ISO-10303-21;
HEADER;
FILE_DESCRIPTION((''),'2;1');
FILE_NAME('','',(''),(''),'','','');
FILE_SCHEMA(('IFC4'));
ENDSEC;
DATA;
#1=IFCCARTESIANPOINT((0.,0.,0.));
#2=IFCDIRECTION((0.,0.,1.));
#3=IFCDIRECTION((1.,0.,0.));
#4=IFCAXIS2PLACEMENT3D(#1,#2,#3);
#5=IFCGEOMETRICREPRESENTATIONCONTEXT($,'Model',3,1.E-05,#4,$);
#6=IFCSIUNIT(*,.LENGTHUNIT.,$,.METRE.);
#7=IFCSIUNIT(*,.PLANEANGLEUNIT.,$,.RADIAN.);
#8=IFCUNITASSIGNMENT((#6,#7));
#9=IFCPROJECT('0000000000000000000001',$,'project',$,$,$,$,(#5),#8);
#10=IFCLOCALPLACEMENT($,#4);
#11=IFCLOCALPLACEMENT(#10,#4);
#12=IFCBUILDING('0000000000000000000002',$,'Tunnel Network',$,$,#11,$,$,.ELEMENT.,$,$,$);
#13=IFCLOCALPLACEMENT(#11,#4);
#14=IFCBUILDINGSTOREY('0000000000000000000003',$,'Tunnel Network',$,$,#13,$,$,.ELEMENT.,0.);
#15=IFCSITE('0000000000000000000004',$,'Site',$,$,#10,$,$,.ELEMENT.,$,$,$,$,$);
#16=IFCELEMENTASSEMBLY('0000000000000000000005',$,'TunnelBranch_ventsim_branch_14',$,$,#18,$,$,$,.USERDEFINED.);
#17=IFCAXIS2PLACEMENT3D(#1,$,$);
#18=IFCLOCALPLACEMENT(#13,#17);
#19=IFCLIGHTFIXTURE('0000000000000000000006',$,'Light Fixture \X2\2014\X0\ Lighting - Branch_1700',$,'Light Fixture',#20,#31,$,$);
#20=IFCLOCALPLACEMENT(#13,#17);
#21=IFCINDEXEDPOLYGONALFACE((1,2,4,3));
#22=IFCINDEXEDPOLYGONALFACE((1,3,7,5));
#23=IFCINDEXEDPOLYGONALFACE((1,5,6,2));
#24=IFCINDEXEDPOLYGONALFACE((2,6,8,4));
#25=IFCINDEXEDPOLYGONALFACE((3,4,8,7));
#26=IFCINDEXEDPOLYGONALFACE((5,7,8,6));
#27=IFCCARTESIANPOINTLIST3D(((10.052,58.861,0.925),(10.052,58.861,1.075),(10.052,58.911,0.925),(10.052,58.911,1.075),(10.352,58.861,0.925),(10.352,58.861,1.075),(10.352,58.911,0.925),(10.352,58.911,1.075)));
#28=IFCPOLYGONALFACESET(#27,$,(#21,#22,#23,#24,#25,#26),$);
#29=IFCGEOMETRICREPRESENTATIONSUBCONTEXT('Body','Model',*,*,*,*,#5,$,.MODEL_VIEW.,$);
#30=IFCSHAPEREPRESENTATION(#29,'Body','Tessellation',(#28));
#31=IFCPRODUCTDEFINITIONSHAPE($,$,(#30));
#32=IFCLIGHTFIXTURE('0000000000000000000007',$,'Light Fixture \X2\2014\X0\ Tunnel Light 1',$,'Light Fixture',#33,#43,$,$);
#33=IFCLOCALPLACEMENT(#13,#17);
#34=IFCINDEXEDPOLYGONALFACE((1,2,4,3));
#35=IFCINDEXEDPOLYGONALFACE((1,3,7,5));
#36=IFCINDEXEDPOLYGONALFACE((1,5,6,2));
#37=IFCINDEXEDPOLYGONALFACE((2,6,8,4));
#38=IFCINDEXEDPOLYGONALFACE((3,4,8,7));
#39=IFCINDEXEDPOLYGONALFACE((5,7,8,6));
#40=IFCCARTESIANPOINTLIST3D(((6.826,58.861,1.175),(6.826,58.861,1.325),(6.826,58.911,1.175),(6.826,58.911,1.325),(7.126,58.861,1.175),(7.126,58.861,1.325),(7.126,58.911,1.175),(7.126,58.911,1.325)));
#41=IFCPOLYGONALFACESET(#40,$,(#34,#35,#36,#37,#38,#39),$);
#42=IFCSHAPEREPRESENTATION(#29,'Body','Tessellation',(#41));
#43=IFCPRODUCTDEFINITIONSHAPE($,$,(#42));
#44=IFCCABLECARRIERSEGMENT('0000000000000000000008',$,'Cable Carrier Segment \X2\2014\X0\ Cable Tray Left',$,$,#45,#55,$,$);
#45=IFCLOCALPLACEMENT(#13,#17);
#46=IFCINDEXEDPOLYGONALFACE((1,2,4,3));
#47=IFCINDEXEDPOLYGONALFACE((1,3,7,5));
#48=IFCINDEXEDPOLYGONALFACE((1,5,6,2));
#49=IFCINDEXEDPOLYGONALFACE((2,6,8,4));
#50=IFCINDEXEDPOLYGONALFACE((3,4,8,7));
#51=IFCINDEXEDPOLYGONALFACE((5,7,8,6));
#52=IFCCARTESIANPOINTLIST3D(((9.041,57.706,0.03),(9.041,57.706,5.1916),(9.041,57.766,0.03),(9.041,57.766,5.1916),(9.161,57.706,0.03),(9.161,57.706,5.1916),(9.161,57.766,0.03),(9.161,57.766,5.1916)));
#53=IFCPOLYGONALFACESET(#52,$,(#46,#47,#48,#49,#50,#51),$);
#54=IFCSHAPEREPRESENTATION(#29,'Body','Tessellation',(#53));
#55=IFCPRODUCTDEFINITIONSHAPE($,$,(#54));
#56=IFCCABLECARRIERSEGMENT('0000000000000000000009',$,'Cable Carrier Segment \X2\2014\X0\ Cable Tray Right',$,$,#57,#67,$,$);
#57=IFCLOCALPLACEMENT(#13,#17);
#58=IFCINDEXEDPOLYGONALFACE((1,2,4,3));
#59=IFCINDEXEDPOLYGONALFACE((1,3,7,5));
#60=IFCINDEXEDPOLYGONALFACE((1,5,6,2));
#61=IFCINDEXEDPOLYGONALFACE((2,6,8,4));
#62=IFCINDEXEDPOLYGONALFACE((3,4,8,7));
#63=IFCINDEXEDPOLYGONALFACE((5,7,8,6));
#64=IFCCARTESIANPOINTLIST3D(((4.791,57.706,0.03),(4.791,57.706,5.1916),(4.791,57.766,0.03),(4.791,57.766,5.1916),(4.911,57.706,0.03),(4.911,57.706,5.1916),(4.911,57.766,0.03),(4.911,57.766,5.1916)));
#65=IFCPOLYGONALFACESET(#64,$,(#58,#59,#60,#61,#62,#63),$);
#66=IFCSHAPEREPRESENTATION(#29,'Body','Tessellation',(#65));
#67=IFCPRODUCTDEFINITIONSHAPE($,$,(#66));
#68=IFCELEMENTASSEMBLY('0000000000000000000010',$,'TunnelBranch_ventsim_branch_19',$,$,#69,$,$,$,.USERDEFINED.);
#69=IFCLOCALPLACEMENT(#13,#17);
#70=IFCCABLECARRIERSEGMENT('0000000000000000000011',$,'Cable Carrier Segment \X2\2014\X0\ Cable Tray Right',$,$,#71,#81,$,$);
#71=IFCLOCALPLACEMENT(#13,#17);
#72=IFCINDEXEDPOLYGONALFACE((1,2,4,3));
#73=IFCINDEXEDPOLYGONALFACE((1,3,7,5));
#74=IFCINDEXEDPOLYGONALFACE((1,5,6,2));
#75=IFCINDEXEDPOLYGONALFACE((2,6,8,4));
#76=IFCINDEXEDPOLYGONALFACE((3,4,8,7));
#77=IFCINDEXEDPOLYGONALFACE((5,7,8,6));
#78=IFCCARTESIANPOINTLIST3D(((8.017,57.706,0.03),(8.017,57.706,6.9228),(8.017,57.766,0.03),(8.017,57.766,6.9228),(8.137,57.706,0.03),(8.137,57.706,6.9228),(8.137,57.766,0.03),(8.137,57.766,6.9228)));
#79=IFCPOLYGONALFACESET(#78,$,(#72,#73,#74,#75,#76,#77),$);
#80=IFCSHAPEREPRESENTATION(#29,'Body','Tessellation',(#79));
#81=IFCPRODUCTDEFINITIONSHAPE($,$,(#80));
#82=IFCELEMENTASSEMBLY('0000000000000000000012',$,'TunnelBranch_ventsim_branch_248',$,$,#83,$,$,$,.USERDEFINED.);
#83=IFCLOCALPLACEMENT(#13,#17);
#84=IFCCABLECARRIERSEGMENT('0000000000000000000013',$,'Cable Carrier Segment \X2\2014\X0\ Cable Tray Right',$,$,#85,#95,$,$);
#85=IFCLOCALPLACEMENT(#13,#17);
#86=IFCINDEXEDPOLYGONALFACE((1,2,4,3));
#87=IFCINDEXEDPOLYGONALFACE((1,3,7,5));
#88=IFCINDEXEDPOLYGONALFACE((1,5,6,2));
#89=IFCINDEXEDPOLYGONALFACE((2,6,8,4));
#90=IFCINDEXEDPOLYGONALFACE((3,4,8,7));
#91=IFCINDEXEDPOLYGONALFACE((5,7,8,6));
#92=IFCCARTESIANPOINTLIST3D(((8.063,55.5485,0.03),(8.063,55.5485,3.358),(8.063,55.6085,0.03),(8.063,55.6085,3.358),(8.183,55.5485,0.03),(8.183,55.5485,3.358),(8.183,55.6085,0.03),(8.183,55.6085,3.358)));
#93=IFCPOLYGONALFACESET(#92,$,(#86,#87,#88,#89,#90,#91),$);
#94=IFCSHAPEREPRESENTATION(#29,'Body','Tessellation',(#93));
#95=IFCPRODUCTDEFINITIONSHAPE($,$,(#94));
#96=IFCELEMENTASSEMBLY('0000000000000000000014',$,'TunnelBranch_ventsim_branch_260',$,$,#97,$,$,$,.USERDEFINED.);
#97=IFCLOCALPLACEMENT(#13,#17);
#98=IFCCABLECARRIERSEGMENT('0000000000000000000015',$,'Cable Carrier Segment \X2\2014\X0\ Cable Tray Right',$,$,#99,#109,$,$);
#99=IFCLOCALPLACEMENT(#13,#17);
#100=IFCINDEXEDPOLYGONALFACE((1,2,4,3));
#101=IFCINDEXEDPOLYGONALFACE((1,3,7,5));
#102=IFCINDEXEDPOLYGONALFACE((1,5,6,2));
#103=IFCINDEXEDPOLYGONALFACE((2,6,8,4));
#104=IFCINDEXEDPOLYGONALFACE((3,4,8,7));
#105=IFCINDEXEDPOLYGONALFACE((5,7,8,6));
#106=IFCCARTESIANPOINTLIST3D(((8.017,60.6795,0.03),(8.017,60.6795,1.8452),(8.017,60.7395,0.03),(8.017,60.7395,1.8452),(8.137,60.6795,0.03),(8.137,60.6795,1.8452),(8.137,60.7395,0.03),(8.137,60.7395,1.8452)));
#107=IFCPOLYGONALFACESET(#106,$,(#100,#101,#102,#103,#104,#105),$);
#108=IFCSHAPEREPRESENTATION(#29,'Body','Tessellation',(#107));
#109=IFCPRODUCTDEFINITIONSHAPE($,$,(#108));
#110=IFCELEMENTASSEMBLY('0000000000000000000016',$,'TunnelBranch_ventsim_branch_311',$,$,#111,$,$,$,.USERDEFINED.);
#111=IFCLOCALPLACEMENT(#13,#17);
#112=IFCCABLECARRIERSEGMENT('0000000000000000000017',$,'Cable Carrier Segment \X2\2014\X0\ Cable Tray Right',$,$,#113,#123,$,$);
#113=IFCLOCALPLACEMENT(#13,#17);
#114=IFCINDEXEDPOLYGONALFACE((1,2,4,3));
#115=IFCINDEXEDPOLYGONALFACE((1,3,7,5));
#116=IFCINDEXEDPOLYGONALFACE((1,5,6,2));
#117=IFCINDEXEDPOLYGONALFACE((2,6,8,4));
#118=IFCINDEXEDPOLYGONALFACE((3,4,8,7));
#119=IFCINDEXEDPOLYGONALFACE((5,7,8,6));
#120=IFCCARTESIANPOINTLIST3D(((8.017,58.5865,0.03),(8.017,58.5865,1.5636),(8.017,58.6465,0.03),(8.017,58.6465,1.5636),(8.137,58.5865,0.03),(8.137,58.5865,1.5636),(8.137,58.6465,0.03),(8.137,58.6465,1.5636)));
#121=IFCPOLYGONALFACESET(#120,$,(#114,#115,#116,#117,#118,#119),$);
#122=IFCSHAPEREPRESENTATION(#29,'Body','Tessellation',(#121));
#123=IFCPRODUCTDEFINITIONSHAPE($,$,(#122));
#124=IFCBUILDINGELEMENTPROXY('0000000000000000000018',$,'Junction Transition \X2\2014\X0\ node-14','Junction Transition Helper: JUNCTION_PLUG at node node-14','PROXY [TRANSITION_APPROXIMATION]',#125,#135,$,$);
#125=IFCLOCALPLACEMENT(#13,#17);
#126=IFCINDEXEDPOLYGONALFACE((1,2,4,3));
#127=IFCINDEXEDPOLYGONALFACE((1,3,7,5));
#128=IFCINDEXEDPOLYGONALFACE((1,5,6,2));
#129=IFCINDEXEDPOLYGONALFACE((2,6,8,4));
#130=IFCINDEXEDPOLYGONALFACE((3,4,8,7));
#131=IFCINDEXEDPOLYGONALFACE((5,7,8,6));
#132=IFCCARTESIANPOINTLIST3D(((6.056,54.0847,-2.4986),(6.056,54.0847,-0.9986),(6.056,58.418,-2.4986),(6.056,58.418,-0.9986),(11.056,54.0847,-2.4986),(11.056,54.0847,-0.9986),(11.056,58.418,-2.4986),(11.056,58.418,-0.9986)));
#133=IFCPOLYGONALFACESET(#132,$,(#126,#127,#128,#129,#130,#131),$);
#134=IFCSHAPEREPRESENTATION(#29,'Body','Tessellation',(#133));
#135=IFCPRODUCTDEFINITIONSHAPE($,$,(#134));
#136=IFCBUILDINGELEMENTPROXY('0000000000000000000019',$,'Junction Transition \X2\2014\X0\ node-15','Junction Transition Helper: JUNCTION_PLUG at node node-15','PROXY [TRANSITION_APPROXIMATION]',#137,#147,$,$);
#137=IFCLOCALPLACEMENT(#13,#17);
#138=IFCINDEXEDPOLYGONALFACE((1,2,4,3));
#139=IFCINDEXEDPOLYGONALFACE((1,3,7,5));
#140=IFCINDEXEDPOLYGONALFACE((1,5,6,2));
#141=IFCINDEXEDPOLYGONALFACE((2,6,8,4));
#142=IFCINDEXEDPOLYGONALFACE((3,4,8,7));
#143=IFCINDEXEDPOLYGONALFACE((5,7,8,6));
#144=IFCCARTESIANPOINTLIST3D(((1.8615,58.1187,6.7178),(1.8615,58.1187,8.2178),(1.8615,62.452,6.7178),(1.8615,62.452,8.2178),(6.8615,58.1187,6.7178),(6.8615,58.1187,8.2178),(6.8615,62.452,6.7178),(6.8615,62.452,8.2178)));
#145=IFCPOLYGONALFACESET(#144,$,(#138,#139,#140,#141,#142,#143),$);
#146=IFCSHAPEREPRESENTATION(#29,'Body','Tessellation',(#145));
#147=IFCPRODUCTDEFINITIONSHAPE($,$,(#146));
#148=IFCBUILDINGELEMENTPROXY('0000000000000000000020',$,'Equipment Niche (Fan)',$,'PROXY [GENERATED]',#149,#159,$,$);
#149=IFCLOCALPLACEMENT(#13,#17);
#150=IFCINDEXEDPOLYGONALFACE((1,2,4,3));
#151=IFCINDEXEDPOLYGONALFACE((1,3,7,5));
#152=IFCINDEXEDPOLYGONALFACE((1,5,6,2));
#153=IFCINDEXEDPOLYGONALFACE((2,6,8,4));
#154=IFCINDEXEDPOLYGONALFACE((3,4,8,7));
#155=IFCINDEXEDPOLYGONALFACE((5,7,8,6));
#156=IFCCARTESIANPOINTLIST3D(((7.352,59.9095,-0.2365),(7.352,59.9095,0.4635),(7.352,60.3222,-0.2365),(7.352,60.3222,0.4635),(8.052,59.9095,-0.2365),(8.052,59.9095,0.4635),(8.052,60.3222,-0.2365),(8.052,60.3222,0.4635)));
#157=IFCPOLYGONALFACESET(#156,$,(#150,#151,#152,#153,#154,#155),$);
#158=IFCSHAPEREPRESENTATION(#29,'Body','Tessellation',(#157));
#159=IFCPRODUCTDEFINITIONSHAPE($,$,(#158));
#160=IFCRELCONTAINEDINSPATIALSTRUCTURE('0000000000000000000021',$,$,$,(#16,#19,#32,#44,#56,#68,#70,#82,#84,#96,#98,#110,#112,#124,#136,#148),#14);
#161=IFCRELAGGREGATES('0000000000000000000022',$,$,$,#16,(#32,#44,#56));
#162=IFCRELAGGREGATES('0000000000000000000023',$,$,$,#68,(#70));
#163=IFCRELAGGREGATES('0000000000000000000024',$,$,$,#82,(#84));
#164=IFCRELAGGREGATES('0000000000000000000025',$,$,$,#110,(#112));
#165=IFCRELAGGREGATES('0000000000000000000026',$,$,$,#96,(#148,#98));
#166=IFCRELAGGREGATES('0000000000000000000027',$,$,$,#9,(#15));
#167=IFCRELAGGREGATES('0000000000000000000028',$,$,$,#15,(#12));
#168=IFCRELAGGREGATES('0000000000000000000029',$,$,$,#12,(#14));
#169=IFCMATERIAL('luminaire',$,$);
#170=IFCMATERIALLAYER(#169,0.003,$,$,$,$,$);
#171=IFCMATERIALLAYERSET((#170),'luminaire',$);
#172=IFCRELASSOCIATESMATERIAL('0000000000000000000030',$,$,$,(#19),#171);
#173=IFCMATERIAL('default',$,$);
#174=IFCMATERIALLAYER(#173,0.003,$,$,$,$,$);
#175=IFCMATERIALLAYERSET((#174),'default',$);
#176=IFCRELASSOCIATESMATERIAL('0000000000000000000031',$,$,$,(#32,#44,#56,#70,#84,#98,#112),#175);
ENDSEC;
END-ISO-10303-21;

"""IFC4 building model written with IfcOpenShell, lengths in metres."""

from ifc_helpers import new_model, si_unit, frame, origin_with_axes, origin_2d_with_axis, place, context, subcontext, project, spatial, rectangle, extrude, material, layer, layer_set, layer_usage, element, aggregate, save


model = new_model("IFC4")

# Units and contexts
model_context = context("Model", 3, precision=1e-05, world=origin_with_axes())
body_context = subcontext(model_context, "Body", "Model", "MODEL_VIEW")
ifc_project = project(units=[si_unit("LENGTHUNIT", "METRE"), si_unit("PLANEANGLEUNIT", "RADIAN")], contexts=[model_context])

# Site, building, storey
site_placement = place(None, origin_with_axes())
site = spatial("IfcSite", under=ifc_project, at=site_placement, Name="Site", CompositionType="ELEMENT")
building_placement = place(site_placement, origin_with_axes())
building = spatial("IfcBuilding", under=site, at=building_placement, Name="Tunnel Network", CompositionType="ELEMENT")
storey_placement = place(building_placement, origin_with_axes())
storey = spatial("IfcBuildingStorey", under=building, at=storey_placement, Name="Tunnel Network", CompositionType="ELEMENT", Elevation=0.0)

# Element assembly
assembly_1_placement = place(storey_placement, frame((6.976, 58.861, 1.25), z_axis=(0.0, 1.0, 0.0), x_axis=(-1.0, 0.0, 0.0)))
assembly_1 = element("IfcElementAssembly", 1, at=assembly_1_placement, inside=storey, Name="TunnelBranch_ventsim_branch_14", PredefinedType="USERDEFINED")
ifc_material_1 = material(Name="default")
ifc_layer_1 = layer(ifc_material_1, 0.003)
ifc_layer_set_1 = layer_set([ifc_layer_1], Name="default")

# Light fixtures
ifc_material_2 = material(Name="luminaire")
ifc_layer_2 = layer(ifc_material_2, 0.003)
ifc_layer_set_2 = layer_set([ifc_layer_2], Name="luminaire")
ifc_layer_usage_1 = layer_usage(ifc_layer_set_2, "AXIS2", "POSITIVE", 0.0)
light_fixture_1_placement = place(storey_placement, frame((10.202, 58.861, 1.0), z_axis=(0.0, 1.0, 0.0), x_axis=(-1.0, 0.0, 0.0)))
element("IfcLightFixture", 2, at=light_fixture_1_placement, inside=storey, material=ifc_layer_usage_1, Name="Light Fixture — Lighting - Branch_1700", ObjectType="Light Fixture", context=body_context, shape_type="SweptSolid", body=[
    extrude(rectangle(XDim=0.3, YDim=0.15, at=origin_2d_with_axis()), origin_with_axes(), (0.0, 0.0, 1.0), 0.05),
])
ifc_layer_usage_2 = layer_usage(ifc_layer_set_1, "AXIS2", "POSITIVE", 0.0)
light_fixture_2_placement = place(storey_placement, frame((6.976, 58.861, 1.25), z_axis=(0.0, 1.0, 0.0), x_axis=(-1.0, 0.0, 0.0)))
light_fixture_2 = element("IfcLightFixture", 3, at=light_fixture_2_placement, inside=storey, material=ifc_layer_usage_2, Name="Light Fixture — Tunnel Light 1", ObjectType="Light Fixture", context=body_context, shape_type="SweptSolid", body=[
    extrude(rectangle(XDim=0.3, YDim=0.15, at=origin_2d_with_axis()), origin_with_axes(), (0.0, 0.0, 1.0), 0.05),
])

# Cable carrier segments
ifc_layer_usage_3 = layer_usage(ifc_layer_set_1, "AXIS2", "POSITIVE", 0.0)
cable_carrier_segment_1_placement = place(storey_placement, frame((9.101, 57.736, 0.03), z_axis=(0.0, 0.0, 1.0), x_axis=(-1.0, 0.0, 0.0)))
cable_carrier_segment_1 = element("IfcCableCarrierSegment", 4, at=cable_carrier_segment_1_placement, inside=storey, material=ifc_layer_usage_3, Name="Cable Carrier Segment — Cable Tray Left", context=body_context, shape_type="SweptSolid", body=[
    extrude(rectangle(XDim=0.12, YDim=0.06, at=origin_2d_with_axis()), origin_with_axes(), (0.0, 0.0, 1.0), 5.1616),
])
ifc_layer_usage_4 = layer_usage(ifc_layer_set_1, "AXIS2", "POSITIVE", 0.0)
cable_carrier_segment_2_placement = place(storey_placement, frame((4.851, 57.736, 0.03), z_axis=(0.0, 0.0, 1.0), x_axis=(-1.0, 0.0, 0.0)))
cable_carrier_segment_2 = element("IfcCableCarrierSegment", 5, at=cable_carrier_segment_2_placement, inside=storey, material=ifc_layer_usage_4, Name="Cable Carrier Segment — Cable Tray Right", context=body_context, shape_type="SweptSolid", body=[
    extrude(rectangle(XDim=0.12, YDim=0.06, at=origin_2d_with_axis()), origin_with_axes(), (0.0, 0.0, 1.0), 5.1616),
])
aggregate(assembly_1, [light_fixture_2, cable_carrier_segment_1, cable_carrier_segment_2])

# Element assemblies, cable carrier segments
assembly_2_placement = place(storey_placement, frame((10.202, 58.861, 1.0), z_axis=(0.0, 1.0, 0.0), x_axis=(-1.0, 0.0, 0.0)))
assembly_2 = element("IfcElementAssembly", 6, at=assembly_2_placement, inside=storey, Name="TunnelBranch_ventsim_branch_19", PredefinedType="USERDEFINED")
ifc_layer_usage_5 = layer_usage(ifc_layer_set_1, "AXIS2", "POSITIVE", 0.0)
cable_carrier_segment_3_placement = place(storey_placement, frame((8.077, 57.736, 0.03), z_axis=(0.0, 0.0, 1.0), x_axis=(-1.0, 0.0, 0.0)))
cable_carrier_segment_3 = element("IfcCableCarrierSegment", 7, at=cable_carrier_segment_3_placement, inside=storey, material=ifc_layer_usage_5, Name="Cable Carrier Segment — Cable Tray Right", context=body_context, shape_type="SweptSolid", body=[
    extrude(rectangle(XDim=0.12, YDim=0.06, at=origin_2d_with_axis()), origin_with_axes(), (0.0, 0.0, 1.0), 6.8928),
])
aggregate(assembly_2, [cable_carrier_segment_3])
assembly_3_placement = place(storey_placement, frame((10.248, 56.4785, 1.25), z_axis=(0.0, 1.0, 0.0), x_axis=(-1.0, 0.0, 0.0)))
assembly_3 = element("IfcElementAssembly", 8, at=assembly_3_placement, inside=storey, Name="TunnelBranch_ventsim_branch_248", PredefinedType="USERDEFINED")
ifc_layer_usage_6 = layer_usage(ifc_layer_set_1, "AXIS2", "POSITIVE", 0.0)
cable_carrier_segment_4_placement = place(storey_placement, frame((8.123, 55.5785, 0.03), z_axis=(0.0, 0.0, 1.0), x_axis=(-1.0, 0.0, 0.0)))
cable_carrier_segment_4 = element("IfcCableCarrierSegment", 9, at=cable_carrier_segment_4_placement, inside=storey, material=ifc_layer_usage_6, Name="Cable Carrier Segment — Cable Tray Right", context=body_context, shape_type="SweptSolid", body=[
    extrude(rectangle(XDim=0.12, YDim=0.06, at=origin_2d_with_axis()), origin_with_axes(), (0.0, 0.0, 1.0), 3.328),
])
aggregate(assembly_3, [cable_carrier_segment_4])
assembly_4_placement = place(storey_placement, frame((7.702, 59.9095, 0.1135), z_axis=(0.0, 1.0, 0.0), x_axis=(-1.0, 0.0, 0.0)))
assembly_4 = element("IfcElementAssembly", 10, at=assembly_4_placement, inside=storey, Name="TunnelBranch_ventsim_branch_260", PredefinedType="USERDEFINED")
ifc_layer_usage_7 = layer_usage(ifc_layer_set_1, "AXIS2", "POSITIVE", 0.0)
cable_carrier_segment_5_placement = place(storey_placement, frame((8.077, 60.7095, 0.03), z_axis=(0.0, 0.0, 1.0), x_axis=(-1.0, 0.0, 0.0)))
cable_carrier_segment_5 = element("IfcCableCarrierSegment", 11, at=cable_carrier_segment_5_placement, inside=storey, material=ifc_layer_usage_7, Name="Cable Carrier Segment — Cable Tray Right", context=body_context, shape_type="SweptSolid", body=[
    extrude(rectangle(XDim=0.12, YDim=0.06, at=origin_2d_with_axis()), origin_with_axes(), (0.0, 0.0, 1.0), 1.8152),
])
assembly_5_placement = place(storey_placement, frame((10.202, 59.5165, 1.0), z_axis=(0.0, 1.0, 0.0), x_axis=(-1.0, 0.0, 0.0)))
assembly_5 = element("IfcElementAssembly", 12, at=assembly_5_placement, inside=storey, Name="TunnelBranch_ventsim_branch_311", PredefinedType="USERDEFINED")
ifc_layer_usage_8 = layer_usage(ifc_layer_set_1, "AXIS2", "POSITIVE", 0.0)
cable_carrier_segment_6_placement = place(storey_placement, frame((8.077, 58.6165, 0.03), z_axis=(0.0, 0.0, 1.0), x_axis=(-1.0, 0.0, 0.0)))
cable_carrier_segment_6 = element("IfcCableCarrierSegment", 13, at=cable_carrier_segment_6_placement, inside=storey, material=ifc_layer_usage_8, Name="Cable Carrier Segment — Cable Tray Right", context=body_context, shape_type="SweptSolid", body=[
    extrude(rectangle(XDim=0.12, YDim=0.06, at=origin_2d_with_axis()), origin_with_axes(), (0.0, 0.0, 1.0), 1.5336),
])
aggregate(assembly_5, [cable_carrier_segment_6])

# Building element proxies
for number, where, z_axis, x_axis, name, description in (
    (14, (8.556, 56.2514, -2.4986), (0.0, 0.0, 1.0), (1.0, 0.0, 0.0), "Junction Transition — node-14", "Junction Transition Helper: JUNCTION_PLUG at node node-14"),
    (15, (4.3615, 60.2854, 6.7178), (0.0, 0.0, 1.0), (1.0, 0.0, 0.0), "Junction Transition — node-15", "Junction Transition Helper: JUNCTION_PLUG at node node-15"),
):
    element("IfcBuildingElementProxy", number, at=place(storey_placement, frame(where, z_axis=z_axis, x_axis=x_axis)), inside=storey, Name=name, Description=description, ObjectType="PROXY [TRANSITION_APPROXIMATION]", context=body_context, shape_type="SweptSolid", body=[
        extrude(rectangle(XDim=5.0, YDim=4.3333, at=origin_2d_with_axis()), origin_with_axes(), (0.0, 0.0, 1.0), 1.5),
    ])

# Building element proxy
proxy_placement = place(storey_placement, frame((7.702, 59.9095, 0.1135), z_axis=(0.0, 1.0, 0.0), x_axis=(-1.0, 0.0, 0.0)))
proxy = element("IfcBuildingElementProxy", 16, at=proxy_placement, inside=storey, Name="Equipment Niche (Fan)", ObjectType="PROXY [GENERATED]", context=body_context, shape_type="SweptSolid", body=[
    extrude(rectangle(XDim=0.7, YDim=0.7, at=origin_2d_with_axis()), origin_with_axes(), (0.0, 0.0, 1.0), 0.4127),
])
aggregate(assembly_4, [proxy, cable_carrier_segment_5])

save(model, "model.ifc")
